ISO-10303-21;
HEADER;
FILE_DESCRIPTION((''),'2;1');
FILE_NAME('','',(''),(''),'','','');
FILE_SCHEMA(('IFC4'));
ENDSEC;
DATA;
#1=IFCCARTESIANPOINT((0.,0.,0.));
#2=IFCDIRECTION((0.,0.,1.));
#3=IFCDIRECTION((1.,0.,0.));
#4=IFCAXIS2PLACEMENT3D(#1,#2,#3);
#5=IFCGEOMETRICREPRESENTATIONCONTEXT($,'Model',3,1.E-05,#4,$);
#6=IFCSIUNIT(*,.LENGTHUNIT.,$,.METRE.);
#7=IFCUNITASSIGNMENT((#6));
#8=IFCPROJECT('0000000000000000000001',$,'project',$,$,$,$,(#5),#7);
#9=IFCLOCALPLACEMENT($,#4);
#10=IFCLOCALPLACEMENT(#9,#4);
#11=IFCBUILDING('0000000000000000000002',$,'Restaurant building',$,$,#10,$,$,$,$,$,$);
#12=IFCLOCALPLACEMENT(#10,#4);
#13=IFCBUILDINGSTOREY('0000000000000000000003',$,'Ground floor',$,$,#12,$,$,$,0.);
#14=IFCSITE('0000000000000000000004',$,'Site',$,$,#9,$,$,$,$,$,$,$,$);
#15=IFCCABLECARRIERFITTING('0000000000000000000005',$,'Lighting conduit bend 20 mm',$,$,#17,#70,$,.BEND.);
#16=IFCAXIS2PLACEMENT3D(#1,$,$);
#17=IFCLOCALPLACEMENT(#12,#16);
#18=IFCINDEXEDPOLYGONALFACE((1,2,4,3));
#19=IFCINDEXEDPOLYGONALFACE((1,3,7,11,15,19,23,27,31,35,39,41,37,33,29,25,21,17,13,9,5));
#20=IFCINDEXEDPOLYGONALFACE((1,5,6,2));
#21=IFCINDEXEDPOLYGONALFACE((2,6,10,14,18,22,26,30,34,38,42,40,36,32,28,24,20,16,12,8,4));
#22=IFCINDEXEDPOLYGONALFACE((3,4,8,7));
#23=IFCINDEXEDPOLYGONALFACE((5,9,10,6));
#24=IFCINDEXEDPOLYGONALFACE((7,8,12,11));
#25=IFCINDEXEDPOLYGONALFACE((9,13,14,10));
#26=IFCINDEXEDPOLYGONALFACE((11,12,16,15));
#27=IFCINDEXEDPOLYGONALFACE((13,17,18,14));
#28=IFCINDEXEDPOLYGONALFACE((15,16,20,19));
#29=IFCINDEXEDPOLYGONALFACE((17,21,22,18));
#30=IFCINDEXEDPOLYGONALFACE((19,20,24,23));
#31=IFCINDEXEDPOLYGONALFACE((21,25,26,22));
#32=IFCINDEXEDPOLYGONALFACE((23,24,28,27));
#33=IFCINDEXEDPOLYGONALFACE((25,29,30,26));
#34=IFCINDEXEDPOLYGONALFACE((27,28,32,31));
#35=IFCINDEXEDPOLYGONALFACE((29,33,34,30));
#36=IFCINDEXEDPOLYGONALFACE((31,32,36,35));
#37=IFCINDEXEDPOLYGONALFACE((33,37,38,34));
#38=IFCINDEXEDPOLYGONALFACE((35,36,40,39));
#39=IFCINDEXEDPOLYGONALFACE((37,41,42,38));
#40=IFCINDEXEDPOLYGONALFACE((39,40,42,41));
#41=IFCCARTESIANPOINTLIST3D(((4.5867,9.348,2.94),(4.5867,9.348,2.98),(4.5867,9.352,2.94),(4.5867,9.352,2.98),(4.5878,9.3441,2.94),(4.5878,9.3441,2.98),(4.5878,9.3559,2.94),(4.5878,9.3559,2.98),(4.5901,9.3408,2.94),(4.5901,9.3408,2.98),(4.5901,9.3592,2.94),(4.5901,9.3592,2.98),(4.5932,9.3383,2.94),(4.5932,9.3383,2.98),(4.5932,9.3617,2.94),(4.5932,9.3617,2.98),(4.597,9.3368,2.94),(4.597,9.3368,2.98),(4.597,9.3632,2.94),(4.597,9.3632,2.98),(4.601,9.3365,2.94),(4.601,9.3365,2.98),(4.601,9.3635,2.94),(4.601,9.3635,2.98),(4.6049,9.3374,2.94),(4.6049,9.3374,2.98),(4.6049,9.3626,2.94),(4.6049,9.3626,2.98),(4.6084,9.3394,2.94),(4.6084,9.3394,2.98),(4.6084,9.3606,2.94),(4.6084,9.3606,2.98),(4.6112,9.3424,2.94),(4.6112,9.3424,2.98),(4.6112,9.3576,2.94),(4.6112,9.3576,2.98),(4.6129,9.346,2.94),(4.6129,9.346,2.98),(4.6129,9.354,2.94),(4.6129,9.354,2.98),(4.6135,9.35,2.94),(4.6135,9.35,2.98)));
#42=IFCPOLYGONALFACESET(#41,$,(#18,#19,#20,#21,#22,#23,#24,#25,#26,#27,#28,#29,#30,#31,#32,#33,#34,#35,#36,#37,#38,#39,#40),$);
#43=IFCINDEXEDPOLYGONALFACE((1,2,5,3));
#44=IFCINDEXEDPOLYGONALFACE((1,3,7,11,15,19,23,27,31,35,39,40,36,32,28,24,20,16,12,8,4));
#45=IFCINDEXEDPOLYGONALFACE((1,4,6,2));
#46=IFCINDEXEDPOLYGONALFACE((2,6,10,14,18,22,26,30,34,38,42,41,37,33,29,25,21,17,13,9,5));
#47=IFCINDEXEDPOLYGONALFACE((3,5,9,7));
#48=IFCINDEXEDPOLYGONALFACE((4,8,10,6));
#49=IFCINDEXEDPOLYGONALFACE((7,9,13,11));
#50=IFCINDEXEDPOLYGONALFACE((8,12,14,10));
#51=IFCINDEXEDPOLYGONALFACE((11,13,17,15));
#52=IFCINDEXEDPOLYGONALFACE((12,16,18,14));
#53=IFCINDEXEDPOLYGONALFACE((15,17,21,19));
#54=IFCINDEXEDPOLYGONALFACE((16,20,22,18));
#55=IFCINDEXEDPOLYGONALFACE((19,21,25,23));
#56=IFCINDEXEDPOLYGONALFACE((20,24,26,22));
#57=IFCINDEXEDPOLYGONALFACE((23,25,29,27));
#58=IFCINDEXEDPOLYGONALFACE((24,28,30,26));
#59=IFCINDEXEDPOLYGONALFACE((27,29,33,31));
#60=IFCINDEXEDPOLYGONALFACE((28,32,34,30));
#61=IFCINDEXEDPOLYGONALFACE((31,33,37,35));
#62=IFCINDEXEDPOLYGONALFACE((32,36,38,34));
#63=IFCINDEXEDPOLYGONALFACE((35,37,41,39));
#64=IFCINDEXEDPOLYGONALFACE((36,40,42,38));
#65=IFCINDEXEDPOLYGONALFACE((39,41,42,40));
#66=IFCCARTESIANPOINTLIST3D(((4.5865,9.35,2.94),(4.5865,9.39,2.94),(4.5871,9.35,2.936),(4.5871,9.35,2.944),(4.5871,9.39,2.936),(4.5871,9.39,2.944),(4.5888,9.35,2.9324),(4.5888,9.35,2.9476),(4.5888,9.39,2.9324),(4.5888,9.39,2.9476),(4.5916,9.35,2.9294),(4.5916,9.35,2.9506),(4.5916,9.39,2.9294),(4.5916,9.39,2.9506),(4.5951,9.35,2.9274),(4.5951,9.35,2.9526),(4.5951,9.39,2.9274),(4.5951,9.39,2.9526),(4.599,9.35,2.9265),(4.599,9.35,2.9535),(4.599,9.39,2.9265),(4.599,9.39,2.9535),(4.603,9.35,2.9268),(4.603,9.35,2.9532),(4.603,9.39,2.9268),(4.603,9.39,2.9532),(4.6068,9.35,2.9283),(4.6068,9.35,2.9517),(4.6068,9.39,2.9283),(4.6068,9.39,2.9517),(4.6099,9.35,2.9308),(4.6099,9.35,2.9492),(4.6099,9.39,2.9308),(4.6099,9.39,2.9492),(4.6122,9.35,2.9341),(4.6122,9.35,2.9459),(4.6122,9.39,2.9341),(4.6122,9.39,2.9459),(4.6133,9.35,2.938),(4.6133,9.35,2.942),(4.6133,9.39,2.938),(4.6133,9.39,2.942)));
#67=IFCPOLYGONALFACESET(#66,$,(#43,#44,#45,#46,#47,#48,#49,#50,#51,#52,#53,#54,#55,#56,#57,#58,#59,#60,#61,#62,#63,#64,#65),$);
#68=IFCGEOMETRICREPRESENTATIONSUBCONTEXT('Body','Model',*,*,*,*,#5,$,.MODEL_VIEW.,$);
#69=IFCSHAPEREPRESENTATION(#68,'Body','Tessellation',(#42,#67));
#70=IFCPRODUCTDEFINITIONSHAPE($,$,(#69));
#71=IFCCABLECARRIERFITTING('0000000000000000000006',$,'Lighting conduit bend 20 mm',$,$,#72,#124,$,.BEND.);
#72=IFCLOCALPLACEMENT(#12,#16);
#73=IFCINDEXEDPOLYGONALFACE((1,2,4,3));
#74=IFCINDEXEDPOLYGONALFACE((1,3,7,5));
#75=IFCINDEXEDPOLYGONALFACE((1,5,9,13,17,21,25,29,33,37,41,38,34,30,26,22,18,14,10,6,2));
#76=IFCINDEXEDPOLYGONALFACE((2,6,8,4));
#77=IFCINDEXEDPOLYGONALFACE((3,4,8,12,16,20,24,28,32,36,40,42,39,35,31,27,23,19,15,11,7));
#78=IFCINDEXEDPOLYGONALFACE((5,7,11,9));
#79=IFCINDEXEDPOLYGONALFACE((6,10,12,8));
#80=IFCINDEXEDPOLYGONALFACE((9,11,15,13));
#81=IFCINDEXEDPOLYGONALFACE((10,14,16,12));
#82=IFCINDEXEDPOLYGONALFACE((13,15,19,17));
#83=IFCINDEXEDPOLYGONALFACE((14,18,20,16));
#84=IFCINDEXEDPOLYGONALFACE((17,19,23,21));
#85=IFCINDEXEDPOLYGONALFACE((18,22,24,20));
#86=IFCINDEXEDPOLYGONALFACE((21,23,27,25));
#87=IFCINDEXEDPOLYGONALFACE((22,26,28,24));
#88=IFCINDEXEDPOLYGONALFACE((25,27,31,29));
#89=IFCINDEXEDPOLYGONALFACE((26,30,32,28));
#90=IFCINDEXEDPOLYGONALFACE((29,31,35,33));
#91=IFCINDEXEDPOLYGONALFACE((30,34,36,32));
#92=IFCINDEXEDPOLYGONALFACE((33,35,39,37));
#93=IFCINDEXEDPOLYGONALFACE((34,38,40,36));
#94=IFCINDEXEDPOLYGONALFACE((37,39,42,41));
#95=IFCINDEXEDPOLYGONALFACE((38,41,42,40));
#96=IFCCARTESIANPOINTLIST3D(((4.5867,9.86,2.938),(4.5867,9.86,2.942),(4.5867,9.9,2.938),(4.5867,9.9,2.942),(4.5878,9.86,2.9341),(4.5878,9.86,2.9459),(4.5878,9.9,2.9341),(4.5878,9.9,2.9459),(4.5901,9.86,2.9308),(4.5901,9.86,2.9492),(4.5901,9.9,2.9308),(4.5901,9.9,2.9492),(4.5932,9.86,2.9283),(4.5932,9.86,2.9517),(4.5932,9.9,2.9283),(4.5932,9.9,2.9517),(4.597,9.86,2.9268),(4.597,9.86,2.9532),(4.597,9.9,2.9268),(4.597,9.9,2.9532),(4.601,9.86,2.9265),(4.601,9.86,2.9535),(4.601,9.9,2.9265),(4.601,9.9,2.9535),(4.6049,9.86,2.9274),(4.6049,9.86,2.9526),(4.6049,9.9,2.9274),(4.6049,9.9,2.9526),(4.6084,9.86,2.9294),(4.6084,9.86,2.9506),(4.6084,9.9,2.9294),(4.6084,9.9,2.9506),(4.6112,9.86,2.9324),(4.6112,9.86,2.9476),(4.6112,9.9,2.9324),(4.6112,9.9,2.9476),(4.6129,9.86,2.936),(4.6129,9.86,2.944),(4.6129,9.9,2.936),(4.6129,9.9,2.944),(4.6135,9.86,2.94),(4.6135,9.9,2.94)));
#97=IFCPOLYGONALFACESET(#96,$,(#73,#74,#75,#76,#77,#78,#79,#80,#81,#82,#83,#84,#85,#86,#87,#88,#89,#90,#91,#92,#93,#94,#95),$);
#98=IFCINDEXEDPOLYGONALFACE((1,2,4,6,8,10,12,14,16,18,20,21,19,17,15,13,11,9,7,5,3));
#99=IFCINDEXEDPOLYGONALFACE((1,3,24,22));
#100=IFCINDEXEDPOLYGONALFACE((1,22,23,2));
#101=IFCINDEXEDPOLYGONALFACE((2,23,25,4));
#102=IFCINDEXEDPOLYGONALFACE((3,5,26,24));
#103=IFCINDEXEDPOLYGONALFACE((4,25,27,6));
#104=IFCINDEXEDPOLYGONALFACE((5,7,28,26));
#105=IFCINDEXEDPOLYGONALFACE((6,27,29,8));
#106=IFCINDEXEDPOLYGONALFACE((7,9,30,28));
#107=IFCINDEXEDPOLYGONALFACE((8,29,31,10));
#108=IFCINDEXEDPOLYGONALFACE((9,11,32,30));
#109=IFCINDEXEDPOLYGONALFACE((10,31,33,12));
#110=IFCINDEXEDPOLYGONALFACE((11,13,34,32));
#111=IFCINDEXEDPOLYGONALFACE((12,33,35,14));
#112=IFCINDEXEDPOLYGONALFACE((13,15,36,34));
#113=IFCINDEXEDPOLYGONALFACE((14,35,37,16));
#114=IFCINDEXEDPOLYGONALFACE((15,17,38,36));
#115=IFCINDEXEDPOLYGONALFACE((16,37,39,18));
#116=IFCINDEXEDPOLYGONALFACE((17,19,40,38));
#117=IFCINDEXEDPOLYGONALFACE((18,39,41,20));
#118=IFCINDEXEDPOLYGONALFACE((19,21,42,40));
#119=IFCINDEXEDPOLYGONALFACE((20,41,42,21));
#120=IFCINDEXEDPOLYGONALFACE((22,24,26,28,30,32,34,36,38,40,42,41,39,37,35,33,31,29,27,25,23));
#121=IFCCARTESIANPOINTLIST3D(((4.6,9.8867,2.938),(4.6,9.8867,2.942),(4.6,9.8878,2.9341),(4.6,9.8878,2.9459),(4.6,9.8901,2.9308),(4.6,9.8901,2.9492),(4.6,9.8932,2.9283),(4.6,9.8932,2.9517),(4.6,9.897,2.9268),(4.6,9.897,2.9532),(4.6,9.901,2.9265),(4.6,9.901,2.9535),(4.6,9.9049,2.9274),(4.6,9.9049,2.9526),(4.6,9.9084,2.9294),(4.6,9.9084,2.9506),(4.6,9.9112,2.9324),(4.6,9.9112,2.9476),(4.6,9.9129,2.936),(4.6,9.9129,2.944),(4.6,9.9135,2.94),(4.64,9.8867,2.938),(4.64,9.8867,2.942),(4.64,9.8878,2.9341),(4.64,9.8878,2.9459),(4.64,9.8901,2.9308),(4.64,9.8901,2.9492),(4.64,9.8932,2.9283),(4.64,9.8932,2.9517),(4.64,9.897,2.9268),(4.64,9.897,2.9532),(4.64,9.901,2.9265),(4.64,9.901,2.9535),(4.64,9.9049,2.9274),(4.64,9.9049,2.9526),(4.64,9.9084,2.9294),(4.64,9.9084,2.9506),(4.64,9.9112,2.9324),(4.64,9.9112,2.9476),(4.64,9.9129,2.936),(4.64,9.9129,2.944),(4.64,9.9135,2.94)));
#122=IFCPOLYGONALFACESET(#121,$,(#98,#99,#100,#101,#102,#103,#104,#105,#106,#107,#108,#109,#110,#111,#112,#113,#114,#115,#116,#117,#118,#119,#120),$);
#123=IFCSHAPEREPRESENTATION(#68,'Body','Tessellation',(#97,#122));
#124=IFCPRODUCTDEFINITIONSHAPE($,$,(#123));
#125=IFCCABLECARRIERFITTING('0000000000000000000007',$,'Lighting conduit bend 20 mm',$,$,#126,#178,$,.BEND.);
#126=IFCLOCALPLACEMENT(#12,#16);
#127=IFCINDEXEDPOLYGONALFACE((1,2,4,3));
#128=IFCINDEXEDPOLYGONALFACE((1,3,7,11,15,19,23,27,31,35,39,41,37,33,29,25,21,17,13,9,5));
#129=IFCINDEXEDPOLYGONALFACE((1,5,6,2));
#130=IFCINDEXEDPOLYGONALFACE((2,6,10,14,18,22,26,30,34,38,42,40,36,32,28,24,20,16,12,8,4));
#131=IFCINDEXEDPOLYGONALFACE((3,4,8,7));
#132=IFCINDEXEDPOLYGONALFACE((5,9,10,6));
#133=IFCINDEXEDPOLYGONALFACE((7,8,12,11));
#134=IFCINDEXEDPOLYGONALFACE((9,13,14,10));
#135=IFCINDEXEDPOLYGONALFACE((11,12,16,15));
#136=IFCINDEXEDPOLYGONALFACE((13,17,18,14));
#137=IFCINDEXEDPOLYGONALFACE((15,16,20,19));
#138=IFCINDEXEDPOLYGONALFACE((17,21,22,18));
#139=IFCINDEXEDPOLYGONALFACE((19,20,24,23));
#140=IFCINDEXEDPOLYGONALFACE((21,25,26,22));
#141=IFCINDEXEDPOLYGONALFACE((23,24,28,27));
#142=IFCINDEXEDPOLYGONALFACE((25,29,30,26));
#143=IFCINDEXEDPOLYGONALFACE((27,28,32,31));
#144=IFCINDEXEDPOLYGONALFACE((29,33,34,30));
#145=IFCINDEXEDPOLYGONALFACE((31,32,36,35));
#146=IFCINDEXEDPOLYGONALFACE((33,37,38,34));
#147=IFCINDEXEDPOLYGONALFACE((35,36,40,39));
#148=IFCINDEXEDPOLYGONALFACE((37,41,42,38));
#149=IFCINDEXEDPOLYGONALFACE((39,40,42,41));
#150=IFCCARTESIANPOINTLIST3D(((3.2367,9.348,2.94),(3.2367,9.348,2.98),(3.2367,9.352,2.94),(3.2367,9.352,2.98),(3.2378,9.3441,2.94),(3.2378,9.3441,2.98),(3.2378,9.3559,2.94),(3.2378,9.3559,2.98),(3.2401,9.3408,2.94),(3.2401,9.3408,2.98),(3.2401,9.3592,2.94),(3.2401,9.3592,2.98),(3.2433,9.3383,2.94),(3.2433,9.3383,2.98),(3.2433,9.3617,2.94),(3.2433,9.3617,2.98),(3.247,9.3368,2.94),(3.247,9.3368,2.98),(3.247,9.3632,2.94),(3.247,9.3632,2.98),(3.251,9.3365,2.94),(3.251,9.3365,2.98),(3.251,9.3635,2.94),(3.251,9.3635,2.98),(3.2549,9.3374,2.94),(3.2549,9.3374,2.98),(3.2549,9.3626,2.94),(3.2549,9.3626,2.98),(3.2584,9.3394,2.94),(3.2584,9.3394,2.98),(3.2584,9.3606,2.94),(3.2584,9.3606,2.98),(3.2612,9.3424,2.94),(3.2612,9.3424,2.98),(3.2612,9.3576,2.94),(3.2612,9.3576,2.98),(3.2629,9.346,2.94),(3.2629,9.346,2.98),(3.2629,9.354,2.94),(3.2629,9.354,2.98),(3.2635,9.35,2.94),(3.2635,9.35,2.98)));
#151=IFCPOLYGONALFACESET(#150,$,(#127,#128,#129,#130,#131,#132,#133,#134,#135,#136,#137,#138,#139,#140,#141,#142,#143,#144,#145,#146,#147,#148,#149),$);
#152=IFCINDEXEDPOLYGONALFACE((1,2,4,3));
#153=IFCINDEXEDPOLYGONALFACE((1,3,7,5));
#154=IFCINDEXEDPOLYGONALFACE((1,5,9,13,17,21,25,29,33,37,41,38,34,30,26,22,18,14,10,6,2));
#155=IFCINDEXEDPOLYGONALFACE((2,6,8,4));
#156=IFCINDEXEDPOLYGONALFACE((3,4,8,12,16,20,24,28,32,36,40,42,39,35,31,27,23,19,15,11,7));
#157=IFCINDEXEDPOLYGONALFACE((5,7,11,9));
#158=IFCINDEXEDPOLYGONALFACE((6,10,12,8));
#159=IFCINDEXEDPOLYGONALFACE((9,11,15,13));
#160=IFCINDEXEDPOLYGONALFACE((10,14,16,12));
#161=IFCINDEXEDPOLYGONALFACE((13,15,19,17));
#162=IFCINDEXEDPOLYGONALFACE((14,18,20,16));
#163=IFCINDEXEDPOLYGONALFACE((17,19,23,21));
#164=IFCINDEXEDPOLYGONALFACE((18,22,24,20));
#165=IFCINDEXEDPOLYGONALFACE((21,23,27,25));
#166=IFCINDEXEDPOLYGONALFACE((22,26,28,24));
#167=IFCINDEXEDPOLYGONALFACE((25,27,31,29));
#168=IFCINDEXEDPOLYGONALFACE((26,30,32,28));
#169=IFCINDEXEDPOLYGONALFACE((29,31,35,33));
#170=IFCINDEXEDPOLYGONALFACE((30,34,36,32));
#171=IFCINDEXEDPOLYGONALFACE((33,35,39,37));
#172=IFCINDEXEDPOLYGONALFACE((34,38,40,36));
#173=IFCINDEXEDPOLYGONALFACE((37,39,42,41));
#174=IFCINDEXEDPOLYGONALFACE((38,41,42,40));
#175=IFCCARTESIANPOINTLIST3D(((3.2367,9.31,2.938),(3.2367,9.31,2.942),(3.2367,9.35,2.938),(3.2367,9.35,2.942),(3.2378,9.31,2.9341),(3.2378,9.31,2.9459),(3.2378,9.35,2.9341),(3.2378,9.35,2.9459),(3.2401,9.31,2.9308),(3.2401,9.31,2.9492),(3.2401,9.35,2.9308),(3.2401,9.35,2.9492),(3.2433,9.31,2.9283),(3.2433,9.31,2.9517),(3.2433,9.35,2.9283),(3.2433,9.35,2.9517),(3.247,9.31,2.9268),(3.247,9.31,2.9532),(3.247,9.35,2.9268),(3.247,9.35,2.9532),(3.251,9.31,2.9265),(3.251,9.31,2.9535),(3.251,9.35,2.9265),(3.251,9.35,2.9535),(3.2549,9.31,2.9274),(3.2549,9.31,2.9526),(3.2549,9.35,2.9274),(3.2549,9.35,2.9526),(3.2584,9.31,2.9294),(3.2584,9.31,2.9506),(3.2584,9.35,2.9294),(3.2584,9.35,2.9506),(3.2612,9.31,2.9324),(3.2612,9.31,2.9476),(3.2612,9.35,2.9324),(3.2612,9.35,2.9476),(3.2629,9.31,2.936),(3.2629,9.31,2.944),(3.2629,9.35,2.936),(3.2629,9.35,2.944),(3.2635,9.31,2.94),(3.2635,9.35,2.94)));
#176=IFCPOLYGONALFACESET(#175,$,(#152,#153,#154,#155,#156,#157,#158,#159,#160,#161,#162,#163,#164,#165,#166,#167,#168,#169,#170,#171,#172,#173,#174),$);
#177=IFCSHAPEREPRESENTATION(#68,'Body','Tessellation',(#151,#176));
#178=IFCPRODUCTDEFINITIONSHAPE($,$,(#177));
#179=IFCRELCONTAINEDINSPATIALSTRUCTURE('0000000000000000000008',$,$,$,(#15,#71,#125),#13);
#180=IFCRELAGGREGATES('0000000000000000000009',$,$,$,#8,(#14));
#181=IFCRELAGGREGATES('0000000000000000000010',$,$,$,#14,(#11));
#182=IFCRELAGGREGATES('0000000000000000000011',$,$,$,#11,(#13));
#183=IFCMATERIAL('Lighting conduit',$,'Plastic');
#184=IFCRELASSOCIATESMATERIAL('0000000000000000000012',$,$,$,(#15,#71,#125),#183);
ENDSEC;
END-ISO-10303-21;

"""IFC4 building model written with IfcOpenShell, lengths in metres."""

from ifc_helpers import new_model, si_unit, frame, origin, origin_with_axes, origin_2d, place, context, subcontext, project, spatial, circle, extrude, material, element, save


model = new_model("IFC4")

# Units and contexts
model_context = context("Model", 3, precision=1e-05, world=origin_with_axes())
body_context = subcontext(model_context, "Body", "Model", "MODEL_VIEW")
ifc_project = project(units=[si_unit("LENGTHUNIT", "METRE")], contexts=[model_context])

# Site, building, storey
site_placement = place(None, origin_with_axes())
site = spatial("IfcSite", under=ifc_project, at=site_placement, Name="Site")
building_placement = place(site_placement, origin_with_axes())
building = spatial("IfcBuilding", under=site, at=building_placement, Name="Restaurant building")
storey_placement = place(building_placement, origin_with_axes())
storey = spatial("IfcBuildingStorey", under=building, at=storey_placement, Name="Ground floor", Elevation=0.0)

# Shared definitions
ifc_material_1 = material(Name="Lighting conduit", Category="Plastic")

# Cable carrier fittings
cable_carrier_fitting_1_placement = place(storey_placement, frame((4.6, 9.35, 2.94)))
element("IfcCableCarrierFitting", 1, at=cable_carrier_fitting_1_placement, inside=storey, material=ifc_material_1, Name="Lighting conduit bend 20 mm", PredefinedType="BEND", context=body_context, shape_type="SweptSolid", body=[
    extrude(circle(Radius=0.0135, at=origin_2d()), origin(), (0.0, 0.0, 1.0), 0.04),
    extrude(circle(Radius=0.0135, at=origin_2d()), frame((0.0, 0.0, 0.0), z_axis=(0.0, 1.0, 0.0), x_axis=(-1.0, 0.0, 0.0)), (0.0, 0.0, 1.0), 0.04),
])
cable_carrier_fitting_2_placement = place(storey_placement, frame((4.6, 9.9, 2.94)))
element("IfcCableCarrierFitting", 2, at=cable_carrier_fitting_2_placement, inside=storey, material=ifc_material_1, Name="Lighting conduit bend 20 mm", PredefinedType="BEND", context=body_context, shape_type="SweptSolid", body=[
    extrude(circle(Radius=0.0135, at=origin_2d()), frame((0.0, 0.0, 0.0), z_axis=(0.0, -1.0, 0.0), x_axis=(1.0, 0.0, 0.0)), (0.0, 0.0, 1.0), 0.04),
    extrude(circle(Radius=0.0135, at=origin_2d()), frame((0.0, 0.0, 0.0), z_axis=(1.0, 0.0, 0.0), x_axis=(0.0, 1.0, 0.0)), (0.0, 0.0, 1.0), 0.04),
])
cable_carrier_fitting_3_placement = place(storey_placement, frame((3.25, 9.35, 2.94)))
element("IfcCableCarrierFitting", 3, at=cable_carrier_fitting_3_placement, inside=storey, material=ifc_material_1, Name="Lighting conduit bend 20 mm", PredefinedType="BEND", context=body_context, shape_type="SweptSolid", body=[
    extrude(circle(Radius=0.0135, at=origin_2d()), origin(), (0.0, 0.0, 1.0), 0.04),
    extrude(circle(Radius=0.0135, at=origin_2d()), frame((0.0, 0.0, 0.0), z_axis=(0.0, -1.0, 0.0), x_axis=(1.0, 0.0, 0.0)), (0.0, 0.0, 1.0), 0.04),
])

save(model, "model.ifc")
